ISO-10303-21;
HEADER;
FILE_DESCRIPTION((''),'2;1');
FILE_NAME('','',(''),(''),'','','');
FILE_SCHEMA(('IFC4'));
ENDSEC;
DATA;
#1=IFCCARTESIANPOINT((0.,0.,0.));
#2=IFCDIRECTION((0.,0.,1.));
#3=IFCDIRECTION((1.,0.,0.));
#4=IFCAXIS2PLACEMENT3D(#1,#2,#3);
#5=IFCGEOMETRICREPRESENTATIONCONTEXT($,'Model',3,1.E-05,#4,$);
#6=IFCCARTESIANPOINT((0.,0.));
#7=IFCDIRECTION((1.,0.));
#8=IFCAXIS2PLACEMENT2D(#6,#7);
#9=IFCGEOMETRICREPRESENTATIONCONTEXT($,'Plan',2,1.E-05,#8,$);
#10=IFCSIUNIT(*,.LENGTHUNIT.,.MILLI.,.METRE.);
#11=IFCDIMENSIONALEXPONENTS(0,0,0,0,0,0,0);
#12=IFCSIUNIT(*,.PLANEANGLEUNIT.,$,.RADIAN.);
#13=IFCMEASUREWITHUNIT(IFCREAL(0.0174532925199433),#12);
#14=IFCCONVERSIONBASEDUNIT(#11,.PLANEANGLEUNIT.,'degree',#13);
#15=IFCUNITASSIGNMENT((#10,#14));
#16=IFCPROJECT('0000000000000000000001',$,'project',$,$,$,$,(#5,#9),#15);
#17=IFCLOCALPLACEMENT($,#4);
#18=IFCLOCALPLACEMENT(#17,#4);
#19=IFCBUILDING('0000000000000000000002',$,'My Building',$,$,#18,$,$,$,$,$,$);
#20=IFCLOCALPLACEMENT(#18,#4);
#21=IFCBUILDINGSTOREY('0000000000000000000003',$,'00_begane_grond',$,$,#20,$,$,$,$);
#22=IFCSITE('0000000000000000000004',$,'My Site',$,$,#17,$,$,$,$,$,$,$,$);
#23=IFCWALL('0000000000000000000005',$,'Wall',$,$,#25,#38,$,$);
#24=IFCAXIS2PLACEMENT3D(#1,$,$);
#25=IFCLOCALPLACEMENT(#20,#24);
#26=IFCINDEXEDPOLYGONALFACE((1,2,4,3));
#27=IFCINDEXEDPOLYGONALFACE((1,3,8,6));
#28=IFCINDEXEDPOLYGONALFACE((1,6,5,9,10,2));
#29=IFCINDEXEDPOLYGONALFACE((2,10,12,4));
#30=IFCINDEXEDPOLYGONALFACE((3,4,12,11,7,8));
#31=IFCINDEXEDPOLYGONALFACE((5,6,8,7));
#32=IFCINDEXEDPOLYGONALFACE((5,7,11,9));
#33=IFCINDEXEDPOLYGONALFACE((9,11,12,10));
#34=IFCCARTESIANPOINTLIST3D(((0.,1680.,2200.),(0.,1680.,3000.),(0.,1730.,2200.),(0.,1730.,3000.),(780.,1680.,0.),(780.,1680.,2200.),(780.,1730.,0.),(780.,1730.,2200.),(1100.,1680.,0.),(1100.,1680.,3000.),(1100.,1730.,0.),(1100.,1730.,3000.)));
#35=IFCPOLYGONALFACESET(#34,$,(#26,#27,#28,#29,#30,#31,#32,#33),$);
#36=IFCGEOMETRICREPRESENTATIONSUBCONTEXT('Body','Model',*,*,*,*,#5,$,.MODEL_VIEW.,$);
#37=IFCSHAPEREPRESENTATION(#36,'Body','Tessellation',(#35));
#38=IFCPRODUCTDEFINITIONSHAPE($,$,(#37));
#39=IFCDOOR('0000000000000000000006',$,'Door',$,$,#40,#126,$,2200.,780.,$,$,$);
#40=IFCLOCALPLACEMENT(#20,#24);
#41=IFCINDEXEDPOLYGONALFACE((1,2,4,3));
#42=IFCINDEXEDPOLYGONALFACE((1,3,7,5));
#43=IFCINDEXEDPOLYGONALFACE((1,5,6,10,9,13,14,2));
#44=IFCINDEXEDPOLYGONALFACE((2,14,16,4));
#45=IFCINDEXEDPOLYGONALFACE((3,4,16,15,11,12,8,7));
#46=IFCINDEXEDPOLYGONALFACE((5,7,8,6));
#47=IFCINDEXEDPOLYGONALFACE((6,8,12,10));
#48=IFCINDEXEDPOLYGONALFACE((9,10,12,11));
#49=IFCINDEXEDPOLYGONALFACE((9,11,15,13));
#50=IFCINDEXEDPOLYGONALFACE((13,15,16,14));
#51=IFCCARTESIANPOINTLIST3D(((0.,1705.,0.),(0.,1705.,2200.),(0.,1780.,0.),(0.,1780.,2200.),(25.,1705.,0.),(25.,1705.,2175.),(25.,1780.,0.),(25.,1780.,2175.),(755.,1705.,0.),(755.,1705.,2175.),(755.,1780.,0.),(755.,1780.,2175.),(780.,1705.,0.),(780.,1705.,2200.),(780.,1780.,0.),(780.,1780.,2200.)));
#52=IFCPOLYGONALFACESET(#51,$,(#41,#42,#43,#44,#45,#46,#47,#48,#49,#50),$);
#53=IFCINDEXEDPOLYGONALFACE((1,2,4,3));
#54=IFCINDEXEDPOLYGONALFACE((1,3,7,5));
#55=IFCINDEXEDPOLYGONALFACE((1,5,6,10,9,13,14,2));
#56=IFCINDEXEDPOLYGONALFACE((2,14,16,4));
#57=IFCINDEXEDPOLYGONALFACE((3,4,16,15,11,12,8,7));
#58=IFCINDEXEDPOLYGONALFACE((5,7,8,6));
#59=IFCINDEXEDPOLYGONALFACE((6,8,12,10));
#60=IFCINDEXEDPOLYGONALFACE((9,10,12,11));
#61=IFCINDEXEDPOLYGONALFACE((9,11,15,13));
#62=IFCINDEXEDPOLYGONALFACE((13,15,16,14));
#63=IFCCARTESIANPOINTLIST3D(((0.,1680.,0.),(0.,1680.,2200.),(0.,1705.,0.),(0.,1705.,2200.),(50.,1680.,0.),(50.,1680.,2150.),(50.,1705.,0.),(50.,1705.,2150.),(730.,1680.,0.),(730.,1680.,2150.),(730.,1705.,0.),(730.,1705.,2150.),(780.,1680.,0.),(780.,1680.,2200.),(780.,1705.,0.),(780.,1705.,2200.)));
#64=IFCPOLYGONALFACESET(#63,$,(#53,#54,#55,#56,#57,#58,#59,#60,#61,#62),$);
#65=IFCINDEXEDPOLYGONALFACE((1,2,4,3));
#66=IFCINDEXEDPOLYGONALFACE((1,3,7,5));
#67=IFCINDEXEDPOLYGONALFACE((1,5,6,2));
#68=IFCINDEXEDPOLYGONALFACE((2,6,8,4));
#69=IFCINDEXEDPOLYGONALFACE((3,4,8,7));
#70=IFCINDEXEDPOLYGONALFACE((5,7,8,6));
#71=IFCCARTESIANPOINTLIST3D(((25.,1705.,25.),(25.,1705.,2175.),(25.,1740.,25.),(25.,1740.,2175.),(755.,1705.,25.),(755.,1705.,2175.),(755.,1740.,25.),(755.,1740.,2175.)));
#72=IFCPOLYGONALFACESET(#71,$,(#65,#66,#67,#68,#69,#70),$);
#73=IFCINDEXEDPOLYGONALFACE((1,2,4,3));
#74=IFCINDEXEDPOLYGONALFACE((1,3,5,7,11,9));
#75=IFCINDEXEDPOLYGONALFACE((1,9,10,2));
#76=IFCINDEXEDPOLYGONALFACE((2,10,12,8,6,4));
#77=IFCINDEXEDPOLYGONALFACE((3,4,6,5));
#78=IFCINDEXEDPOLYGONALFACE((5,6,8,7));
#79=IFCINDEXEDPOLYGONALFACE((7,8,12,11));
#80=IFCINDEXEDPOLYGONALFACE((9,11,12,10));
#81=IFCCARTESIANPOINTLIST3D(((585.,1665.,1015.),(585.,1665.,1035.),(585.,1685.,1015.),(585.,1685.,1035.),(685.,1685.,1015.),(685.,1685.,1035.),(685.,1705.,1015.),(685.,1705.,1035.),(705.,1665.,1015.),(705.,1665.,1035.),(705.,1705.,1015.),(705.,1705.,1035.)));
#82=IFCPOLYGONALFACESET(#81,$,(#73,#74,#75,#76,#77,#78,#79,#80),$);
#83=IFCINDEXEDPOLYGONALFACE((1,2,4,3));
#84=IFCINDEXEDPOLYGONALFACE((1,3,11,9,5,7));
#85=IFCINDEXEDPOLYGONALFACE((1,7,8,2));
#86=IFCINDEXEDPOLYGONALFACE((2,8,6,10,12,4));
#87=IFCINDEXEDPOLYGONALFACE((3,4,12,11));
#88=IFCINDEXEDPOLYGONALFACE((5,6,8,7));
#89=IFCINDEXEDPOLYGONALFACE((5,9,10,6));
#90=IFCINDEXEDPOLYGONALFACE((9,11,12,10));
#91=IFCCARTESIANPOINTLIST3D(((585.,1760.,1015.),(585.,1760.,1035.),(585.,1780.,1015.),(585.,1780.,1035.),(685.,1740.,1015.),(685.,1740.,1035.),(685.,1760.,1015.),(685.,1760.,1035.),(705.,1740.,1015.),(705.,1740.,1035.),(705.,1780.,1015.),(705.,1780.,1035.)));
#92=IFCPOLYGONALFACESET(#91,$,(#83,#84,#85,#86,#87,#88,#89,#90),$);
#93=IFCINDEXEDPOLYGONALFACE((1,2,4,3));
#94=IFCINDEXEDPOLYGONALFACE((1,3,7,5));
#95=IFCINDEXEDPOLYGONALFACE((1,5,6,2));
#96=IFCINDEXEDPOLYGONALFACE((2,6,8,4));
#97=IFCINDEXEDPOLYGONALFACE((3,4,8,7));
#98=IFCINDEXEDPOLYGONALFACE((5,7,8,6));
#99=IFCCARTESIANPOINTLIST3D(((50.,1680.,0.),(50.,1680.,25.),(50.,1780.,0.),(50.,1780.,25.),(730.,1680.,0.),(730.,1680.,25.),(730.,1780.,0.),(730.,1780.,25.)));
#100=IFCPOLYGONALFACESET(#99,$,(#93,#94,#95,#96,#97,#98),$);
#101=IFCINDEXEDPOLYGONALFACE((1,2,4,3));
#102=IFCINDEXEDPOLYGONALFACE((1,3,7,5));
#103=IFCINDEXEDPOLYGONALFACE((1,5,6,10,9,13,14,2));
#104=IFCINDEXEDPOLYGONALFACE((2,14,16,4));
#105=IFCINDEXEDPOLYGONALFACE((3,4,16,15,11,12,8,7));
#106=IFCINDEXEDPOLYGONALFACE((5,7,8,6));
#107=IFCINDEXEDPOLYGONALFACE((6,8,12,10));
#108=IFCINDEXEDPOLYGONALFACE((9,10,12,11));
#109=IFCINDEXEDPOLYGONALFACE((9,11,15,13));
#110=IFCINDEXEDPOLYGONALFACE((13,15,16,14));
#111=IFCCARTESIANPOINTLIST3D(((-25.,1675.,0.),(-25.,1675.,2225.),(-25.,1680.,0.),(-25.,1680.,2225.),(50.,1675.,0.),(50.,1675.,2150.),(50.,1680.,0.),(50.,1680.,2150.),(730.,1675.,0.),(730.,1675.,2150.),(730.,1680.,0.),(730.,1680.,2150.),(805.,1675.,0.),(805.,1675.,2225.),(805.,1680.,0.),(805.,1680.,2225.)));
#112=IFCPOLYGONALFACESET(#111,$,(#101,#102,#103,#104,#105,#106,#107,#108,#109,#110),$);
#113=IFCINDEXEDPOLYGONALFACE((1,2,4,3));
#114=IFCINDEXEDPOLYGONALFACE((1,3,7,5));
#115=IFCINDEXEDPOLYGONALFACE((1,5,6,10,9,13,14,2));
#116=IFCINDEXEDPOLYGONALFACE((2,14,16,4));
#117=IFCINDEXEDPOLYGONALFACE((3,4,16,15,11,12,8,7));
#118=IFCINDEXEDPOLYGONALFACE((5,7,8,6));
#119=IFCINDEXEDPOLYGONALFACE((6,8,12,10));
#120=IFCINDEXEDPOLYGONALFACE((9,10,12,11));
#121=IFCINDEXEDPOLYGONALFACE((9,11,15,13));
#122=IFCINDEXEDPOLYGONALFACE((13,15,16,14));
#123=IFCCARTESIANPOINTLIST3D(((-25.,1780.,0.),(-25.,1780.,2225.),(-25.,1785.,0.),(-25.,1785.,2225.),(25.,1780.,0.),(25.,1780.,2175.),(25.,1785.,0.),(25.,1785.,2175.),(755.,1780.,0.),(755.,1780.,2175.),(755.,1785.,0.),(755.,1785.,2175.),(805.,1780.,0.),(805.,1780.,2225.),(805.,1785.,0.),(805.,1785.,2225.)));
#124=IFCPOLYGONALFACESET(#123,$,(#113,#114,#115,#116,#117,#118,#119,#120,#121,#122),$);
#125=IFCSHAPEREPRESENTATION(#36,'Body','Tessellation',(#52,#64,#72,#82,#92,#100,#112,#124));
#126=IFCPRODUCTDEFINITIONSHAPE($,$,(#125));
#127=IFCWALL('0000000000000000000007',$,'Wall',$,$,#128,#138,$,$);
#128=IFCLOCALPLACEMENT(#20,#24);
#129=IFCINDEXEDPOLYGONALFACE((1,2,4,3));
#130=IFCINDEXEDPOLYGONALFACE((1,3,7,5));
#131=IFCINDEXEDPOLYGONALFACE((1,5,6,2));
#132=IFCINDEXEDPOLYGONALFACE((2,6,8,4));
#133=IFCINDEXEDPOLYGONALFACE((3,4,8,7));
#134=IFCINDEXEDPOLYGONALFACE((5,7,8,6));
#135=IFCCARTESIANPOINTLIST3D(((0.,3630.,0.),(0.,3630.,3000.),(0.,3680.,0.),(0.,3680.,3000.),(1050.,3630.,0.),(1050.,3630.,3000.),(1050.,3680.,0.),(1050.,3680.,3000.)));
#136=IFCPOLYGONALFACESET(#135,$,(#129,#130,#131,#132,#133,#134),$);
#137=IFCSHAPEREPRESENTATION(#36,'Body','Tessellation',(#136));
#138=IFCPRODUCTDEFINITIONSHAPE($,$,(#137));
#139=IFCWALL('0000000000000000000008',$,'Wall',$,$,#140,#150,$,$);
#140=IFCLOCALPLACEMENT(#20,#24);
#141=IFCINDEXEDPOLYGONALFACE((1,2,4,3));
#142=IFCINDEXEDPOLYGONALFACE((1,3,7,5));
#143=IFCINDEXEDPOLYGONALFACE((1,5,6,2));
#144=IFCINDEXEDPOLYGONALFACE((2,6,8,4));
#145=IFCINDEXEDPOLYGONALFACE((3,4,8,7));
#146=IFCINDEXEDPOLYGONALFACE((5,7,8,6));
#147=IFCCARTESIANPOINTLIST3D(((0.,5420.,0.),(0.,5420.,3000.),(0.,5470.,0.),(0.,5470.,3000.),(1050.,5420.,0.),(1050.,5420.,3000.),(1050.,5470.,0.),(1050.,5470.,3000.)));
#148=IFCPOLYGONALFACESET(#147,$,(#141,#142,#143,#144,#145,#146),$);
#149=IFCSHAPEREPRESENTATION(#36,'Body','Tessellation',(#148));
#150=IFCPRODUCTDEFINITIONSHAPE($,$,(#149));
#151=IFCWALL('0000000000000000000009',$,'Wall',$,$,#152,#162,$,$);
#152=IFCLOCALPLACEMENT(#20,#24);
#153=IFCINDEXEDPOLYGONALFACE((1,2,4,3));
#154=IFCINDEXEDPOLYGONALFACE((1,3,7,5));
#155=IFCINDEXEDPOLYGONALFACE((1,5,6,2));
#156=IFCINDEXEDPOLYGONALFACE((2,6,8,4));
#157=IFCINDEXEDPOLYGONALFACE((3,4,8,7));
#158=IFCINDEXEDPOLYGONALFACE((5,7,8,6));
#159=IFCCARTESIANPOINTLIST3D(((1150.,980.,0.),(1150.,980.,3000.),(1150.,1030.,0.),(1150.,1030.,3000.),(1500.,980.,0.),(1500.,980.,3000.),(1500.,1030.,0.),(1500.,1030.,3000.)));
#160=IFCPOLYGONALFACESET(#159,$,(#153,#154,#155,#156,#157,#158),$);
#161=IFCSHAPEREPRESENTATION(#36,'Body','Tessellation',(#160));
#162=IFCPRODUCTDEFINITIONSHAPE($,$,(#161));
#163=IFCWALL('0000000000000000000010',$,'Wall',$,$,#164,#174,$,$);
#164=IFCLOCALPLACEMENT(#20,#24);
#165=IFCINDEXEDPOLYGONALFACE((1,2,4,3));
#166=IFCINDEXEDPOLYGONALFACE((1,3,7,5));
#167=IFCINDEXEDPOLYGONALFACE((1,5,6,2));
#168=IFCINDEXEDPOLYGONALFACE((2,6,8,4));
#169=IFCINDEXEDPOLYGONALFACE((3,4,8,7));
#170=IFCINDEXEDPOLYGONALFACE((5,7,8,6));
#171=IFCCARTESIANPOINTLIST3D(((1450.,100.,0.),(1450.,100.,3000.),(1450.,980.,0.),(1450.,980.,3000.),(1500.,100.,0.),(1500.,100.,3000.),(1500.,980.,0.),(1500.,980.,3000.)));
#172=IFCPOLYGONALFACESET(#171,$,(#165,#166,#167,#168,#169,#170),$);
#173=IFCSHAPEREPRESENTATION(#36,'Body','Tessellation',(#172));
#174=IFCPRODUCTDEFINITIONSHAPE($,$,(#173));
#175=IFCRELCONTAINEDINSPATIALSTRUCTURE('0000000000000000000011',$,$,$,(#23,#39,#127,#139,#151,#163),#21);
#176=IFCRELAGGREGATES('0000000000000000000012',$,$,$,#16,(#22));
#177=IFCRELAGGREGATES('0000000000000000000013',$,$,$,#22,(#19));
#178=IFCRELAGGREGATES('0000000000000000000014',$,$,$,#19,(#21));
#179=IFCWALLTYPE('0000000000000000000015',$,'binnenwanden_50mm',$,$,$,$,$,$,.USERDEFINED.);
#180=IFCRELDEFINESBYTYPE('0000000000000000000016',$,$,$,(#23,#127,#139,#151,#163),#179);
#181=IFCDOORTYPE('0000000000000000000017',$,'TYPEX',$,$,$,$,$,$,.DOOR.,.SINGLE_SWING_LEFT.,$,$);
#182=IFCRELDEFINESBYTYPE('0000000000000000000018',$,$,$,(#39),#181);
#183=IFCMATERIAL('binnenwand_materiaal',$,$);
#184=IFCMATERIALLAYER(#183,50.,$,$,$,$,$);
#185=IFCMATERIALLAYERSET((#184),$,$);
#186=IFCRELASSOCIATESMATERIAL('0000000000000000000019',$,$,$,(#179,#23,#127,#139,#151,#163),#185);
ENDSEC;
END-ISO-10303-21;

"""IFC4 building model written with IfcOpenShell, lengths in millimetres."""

from ifc_helpers import new_model, entity, si_unit, converted_unit, frame, origin_with_axes, origin_2d_with_axis, place, context, subcontext, project, spatial, line, indexed_curve, outline, extrude, shape, source, transform, mapped, material, layer, layer_set, layer_usage, type_object, type_shapes, element, fill, save


model = new_model("IFC4")

# Units and contexts
model_context = context("Model", 3, precision=1e-05, world=origin_with_axes())
plan_context = context("Plan", 2, precision=1e-05, world=origin_2d_with_axis())
body_context_1 = subcontext(model_context, "Body", "Model", "MODEL_VIEW")
body_context_2 = subcontext(plan_context, "Body", "Plan", "PLAN_VIEW")
ifc_project = project(units=[si_unit("LENGTHUNIT", "METRE", prefix="MILLI"), converted_unit("PLANEANGLEUNIT", "degree", entity("IfcReal", 0.0174532925199433), si_unit("PLANEANGLEUNIT", "RADIAN"), dimensions=[0, 0, 0, 0, 0, 0, 0])], contexts=[model_context, plan_context])

# Site, building, storey
site_placement = place(None, origin_with_axes())
site = spatial("IfcSite", under=ifc_project, at=site_placement, Name="My Site")
building_placement = place(site_placement, origin_with_axes())
building = spatial("IfcBuilding", under=site, at=building_placement, Name="My Building")
storey_placement = place(building_placement, origin_with_axes())
storey = spatial("IfcBuildingStorey", under=building, at=storey_placement, Name="00_begane_grond")

# Shared definitions
shared_shape_1 = source(origin_with_axes(), body_context_1, "Body", "SweptSolid", [
    extrude(outline(indexed_curve([(0.0, 0.0), (780.0, 0.0), (780.0, 2200.0), (0.0, 2200.0)], segments=[line(1, 2, 3, 4, 1)])), frame((0.0, -100.0, 0.0), z_axis=(0.0, -1.0, 0.0), x_axis=(1.0, 0.0, 0.0)), (0.0, 0.0, -1.0), 300.0),
])
door_type = type_object("IfcDoorType", Name="TYPEX", OperationType="SINGLE_SWING_LEFT", PredefinedType="DOOR")
shared_shape_2 = source(origin_with_axes(), body_context_1, "Body", "SweptSolid", [
    extrude(outline(indexed_curve([(0.0, 0.0), (0.0, 2200.0), (780.0, 2200.0), (780.0, 0.0), (755.0, 0.0), (755.0, 2175.0), (25.0, 2175.0), (25.0, 0.0)], segments=[line(1, 2, 3, 4, 5, 6, 7, 8, 1)])), frame((0.0, 25.0, 0.0), z_axis=(0.0, -1.0, 0.0), x_axis=(1.0, 0.0, 0.0)), (0.0, 0.0, -1.0), 75.0),
    extrude(outline(indexed_curve([(0.0, 0.0), (0.0, 2200.0), (780.0, 2200.0), (780.0, 0.0), (730.0, 0.0), (730.0, 2150.0), (50.0, 2150.0), (50.0, 0.0)], segments=[line(1, 2, 3, 4, 5, 6, 7, 8, 1)])), frame((0.0, 0.0, 0.0), z_axis=(0.0, -1.0, 0.0), x_axis=(1.0, 0.0, 0.0)), (0.0, 0.0, -1.0), 25.0),
    extrude(outline(indexed_curve([(0.0, 0.0), (730.0, 0.0), (730.0, 35.0), (0.0, 35.0)], segments=[line(1, 2, 3, 4, 1)])), frame((25.0, 25.0, 25.0), z_axis=(0.0, 0.0, 1.0), x_axis=(1.0, 0.0, 0.0)), (0.0, 0.0, 1.0), 2150.0),
    extrude(outline(indexed_curve([(0.0, 0.0), (0.0, -40.0), (-120.0, -40.0), (-120.0, -20.0), (-20.0, -20.0), (-20.0, 0.0)], segments=[line(1, 2, 3, 4, 5, 6, 1)])), frame((705.0, 25.0, 1015.0), z_axis=(0.0, 0.0, 1.0), x_axis=(1.0, 0.0, 0.0)), (0.0, 0.0, 1.0), 20.0),
    extrude(outline(indexed_curve([(0.0, 0.0), (0.0, 40.0), (-120.0, 40.0), (-120.0, 20.0), (-20.0, 20.0), (-20.0, 0.0)], segments=[line(1, 2, 3, 4, 5, 6, 1)])), frame((705.0, 60.0, 1015.0), z_axis=(0.0, 0.0, 1.0), x_axis=(1.0, 0.0, 0.0)), (0.0, 0.0, 1.0), 20.0),
    extrude(outline(indexed_curve([(0.0, 0.0), (680.0, 0.0), (680.0, 100.0), (0.0, 100.0)], segments=[line(1, 2, 3, 4, 1)])), frame((50.0, 0.0, 0.0), z_axis=(0.0, 0.0, 1.0), x_axis=(1.0, 0.0, 0.0)), (0.0, 0.0, 1.0), 25.0),
    extrude(outline(indexed_curve([(0.0, 0.0), (0.0, 2225.0), (830.0, 2225.0), (830.0, 0.0), (755.0, 0.0), (755.0, 2150.0), (75.0, 2150.0), (75.0, 0.0)], segments=[line(1, 2, 3, 4, 5, 6, 7, 8, 1)])), frame((-25.0, -5.0, 0.0), z_axis=(0.0, -1.0, 0.0), x_axis=(1.0, 0.0, 0.0)), (0.0, 0.0, -1.0), 5.0),
    extrude(outline(indexed_curve([(0.0, 0.0), (0.0, 2225.0), (830.0, 2225.0), (830.0, 0.0), (780.0, 0.0), (780.0, 2175.0), (50.0, 2175.0), (50.0, 0.0)], segments=[line(1, 2, 3, 4, 5, 6, 7, 8, 1)])), frame((-25.0, 100.0, 0.0), z_axis=(0.0, -1.0, 0.0), x_axis=(1.0, 0.0, 0.0)), (0.0, 0.0, -1.0), 5.0),
])
shared_shape_3 = source(origin_with_axes(), body_context_2, "Body", "Curve2D", [
    entity("IfcIndexedPolyCurve", entity("IfcCartesianPointList2D", [[0.0, 0.0], [0.0, 100.0], [25.0, 100.0], [25.0, 25.0], [50.0, 25.0], [50.0, 0.0]]), [entity("IfcLineIndex", [1, 2, 3, 4, 5, 6, 1])]),
    entity("IfcIndexedPolyCurve", entity("IfcCartesianPointList2D", [[780.0, 0.0], [780.0, 100.0], [755.0, 100.0], [755.0, 25.0], [730.0, 25.0], [730.0, 0.0]]), [entity("IfcLineIndex", [1, 2, 3, 4, 5, 6, 1])]),
    entity("IfcTrimmedCurve", entity("IfcEllipse", entity("IfcAxis2Placement2D", entity("IfcCartesianPoint", [60.0, 100.0]), entity("IfcDirection", [1.0, 0.0])), 695.0, 730.0), [entity("IfcCartesianPoint", [755.0, 100.0])], [entity("IfcCartesianPoint", [60.0, 830.0])], True, "CARTESIAN"),
    entity("IfcIndexedPolyCurve", entity("IfcCartesianPointList2D", [[25.0, 100.0], [60.0, 100.0], [60.0, 830.0], [25.0, 830.0]]), [entity("IfcLineIndex", [1, 2, 3, 4, 1])]),
])
type_shapes(door_type, [shared_shape_2, shared_shape_3])

# Wall, opening, door
ifc_material_1 = material(Name="binnenwand_materiaal")
ifc_layer_1 = layer(ifc_material_1, 50.0)
ifc_layer_set_1 = layer_set([ifc_layer_1])
ifc_layer_usage_1 = layer_usage(ifc_layer_set_1, "AXIS2", "POSITIVE", 0.0)
wall_type_1 = type_object("IfcWallType", Name="binnenwanden_50mm", PredefinedType="USERDEFINED", material=ifc_layer_set_1)
wall_1_placement = place(storey_placement, frame((0.0, 1680.0, 0.0), z_axis=(0.0, 0.0, 1.0), x_axis=(1.0, -0.000001, 0.0)))
wall_1 = element("IfcWall", 1, at=wall_1_placement, inside=storey, type_object=wall_type_1, material=ifc_layer_usage_1, Name="Wall", context=body_context_1, shape_type="SweptSolid", body=[
    extrude(outline(indexed_curve([(0.0, 0.0), (0.0, 50.0), (1100.0, 50.0), (1100.0, 0.0), (0.0, 0.0)], self_intersect=False)), origin_with_axes(), (0.0, 0.0, 1.0), 3000.0),
])
opening_1_placement = place(wall_1_placement, frame((0.0, 0.0, 0.0), z_axis=(0.0, 0.0, 1.0), x_axis=(1.0, 0.0, 0.0)))
opening_1 = element("IfcOpeningElement", 2, at=opening_1_placement, cuts=wall_1, PredefinedType="OPENING", context=body_context_1, shape_type="MappedRepresentation", body=[
    mapped(shared_shape_1, transform((0.0, 0.0, 0.0), x_axis=(1.0, 0.0, 0.0), y_axis=(0.0, 1.0, 0.0), z_axis=(0.0, 0.0, 1.0), scale=1.0)),
])
door_1_placement = place(opening_1_placement, frame((0.0, 0.0, 0.0), z_axis=(0.0, 0.0, 1.0), x_axis=(1.0, 0.0, 0.0)))
door_1 = element("IfcDoor", 3, at=door_1_placement, inside=storey, type_object=door_type, Name="Door", OverallHeight=2200.0, OverallWidth=780.0, shapes=[
    shape(body_context_1, "Body", "MappedRepresentation", [mapped(shared_shape_2, transform((0.0, 0.0, 0.0), x_axis=(1.0, 0.0, 0.0), y_axis=(0.0, 1.0, 0.0), z_axis=(0.0, 0.0, 1.0), scale=1.0))]),
    shape(body_context_2, "Body", "MappedRepresentation", [mapped(shared_shape_3, transform((0.0, 0.0, 0.0), x_axis=(1.0, 0.0, 0.0), y_axis=(0.0, 1.0, 0.0), z_axis=(0.0, 0.0, 1.0), scale=1.0))]),
])
fill(opening_1, door_1)

# Wall
ifc_layer_usage_2 = layer_usage(ifc_layer_set_1, "AXIS2", "POSITIVE", 0.0)
wall_2_placement = place(storey_placement, frame((0.0, 3630.0, 0.0), z_axis=(0.0, 0.0, 1.0), x_axis=(1.0, -0.000001, 0.0)))
element("IfcWall", 4, at=wall_2_placement, inside=storey, type_object=wall_type_1, material=ifc_layer_usage_2, Name="Wall", context=body_context_1, shape_type="SweptSolid", body=[
    extrude(outline(indexed_curve([(0.0, 0.0), (0.0, 50.0), (1050.0, 50.0), (1050.0, 0.0), (0.0, 0.0)], self_intersect=False)), origin_with_axes(), (0.0, 0.0, 1.0), 3000.0),
])

# Walls
ifc_layer_usage_3 = layer_usage(ifc_layer_set_1, "AXIS2", "POSITIVE", 0.0)
wall_3_placement = place(storey_placement, frame((0.0, 5420.0, 0.0), z_axis=(0.0, 0.0, 1.0), x_axis=(1.0, -0.000001, 0.0)))
element("IfcWall", 5, at=wall_3_placement, inside=storey, type_object=wall_type_1, material=ifc_layer_usage_3, Name="Wall", context=body_context_1, shape_type="SweptSolid", body=[
    extrude(outline(indexed_curve([(0.0, 0.0), (0.0, 50.0), (1050.0, 50.0), (1050.0, 0.0), (0.0, 0.0)], self_intersect=False)), origin_with_axes(), (0.0, 0.0, 1.0), 3000.0),
])
ifc_layer_usage_4 = layer_usage(ifc_layer_set_1, "AXIS2", "POSITIVE", 0.0)
wall_4_placement = place(storey_placement, frame((1150.0, 980.0, 0.0), z_axis=(0.0, 0.0, 1.0), x_axis=(1.0, -0.000002, 0.0)))
element("IfcWall", 6, at=wall_4_placement, inside=storey, type_object=wall_type_1, material=ifc_layer_usage_4, Name="Wall", context=body_context_1, shape_type="SweptSolid", body=[
    extrude(outline(indexed_curve([(0.0, 0.0), (0.0, 50.0), (350.0, 50.0), (350.0, 0.0), (0.0, 0.0)], self_intersect=False)), origin_with_axes(), (0.0, 0.0, 1.0), 3000.0),
])
ifc_layer_usage_5 = layer_usage(ifc_layer_set_1, "AXIS2", "POSITIVE", 0.0)
wall_5_placement = place(storey_placement, frame((1450.0, 980.0, 0.0), z_axis=(0.0, 0.0, 1.0), x_axis=(-0.000002, -1.0, 0.0)))
element("IfcWall", 7, at=wall_5_placement, inside=storey, type_object=wall_type_1, material=ifc_layer_usage_5, Name="Wall", context=body_context_1, shape_type="SweptSolid", body=[
    extrude(outline(indexed_curve([(0.0, 0.0), (0.0, 50.0), (880.0, 50.0), (880.0, 0.0), (0.0, 0.0)], self_intersect=False)), origin_with_axes(), (0.0, 0.0, 1.0), 3000.0),
])

save(model, "model.ifc")
